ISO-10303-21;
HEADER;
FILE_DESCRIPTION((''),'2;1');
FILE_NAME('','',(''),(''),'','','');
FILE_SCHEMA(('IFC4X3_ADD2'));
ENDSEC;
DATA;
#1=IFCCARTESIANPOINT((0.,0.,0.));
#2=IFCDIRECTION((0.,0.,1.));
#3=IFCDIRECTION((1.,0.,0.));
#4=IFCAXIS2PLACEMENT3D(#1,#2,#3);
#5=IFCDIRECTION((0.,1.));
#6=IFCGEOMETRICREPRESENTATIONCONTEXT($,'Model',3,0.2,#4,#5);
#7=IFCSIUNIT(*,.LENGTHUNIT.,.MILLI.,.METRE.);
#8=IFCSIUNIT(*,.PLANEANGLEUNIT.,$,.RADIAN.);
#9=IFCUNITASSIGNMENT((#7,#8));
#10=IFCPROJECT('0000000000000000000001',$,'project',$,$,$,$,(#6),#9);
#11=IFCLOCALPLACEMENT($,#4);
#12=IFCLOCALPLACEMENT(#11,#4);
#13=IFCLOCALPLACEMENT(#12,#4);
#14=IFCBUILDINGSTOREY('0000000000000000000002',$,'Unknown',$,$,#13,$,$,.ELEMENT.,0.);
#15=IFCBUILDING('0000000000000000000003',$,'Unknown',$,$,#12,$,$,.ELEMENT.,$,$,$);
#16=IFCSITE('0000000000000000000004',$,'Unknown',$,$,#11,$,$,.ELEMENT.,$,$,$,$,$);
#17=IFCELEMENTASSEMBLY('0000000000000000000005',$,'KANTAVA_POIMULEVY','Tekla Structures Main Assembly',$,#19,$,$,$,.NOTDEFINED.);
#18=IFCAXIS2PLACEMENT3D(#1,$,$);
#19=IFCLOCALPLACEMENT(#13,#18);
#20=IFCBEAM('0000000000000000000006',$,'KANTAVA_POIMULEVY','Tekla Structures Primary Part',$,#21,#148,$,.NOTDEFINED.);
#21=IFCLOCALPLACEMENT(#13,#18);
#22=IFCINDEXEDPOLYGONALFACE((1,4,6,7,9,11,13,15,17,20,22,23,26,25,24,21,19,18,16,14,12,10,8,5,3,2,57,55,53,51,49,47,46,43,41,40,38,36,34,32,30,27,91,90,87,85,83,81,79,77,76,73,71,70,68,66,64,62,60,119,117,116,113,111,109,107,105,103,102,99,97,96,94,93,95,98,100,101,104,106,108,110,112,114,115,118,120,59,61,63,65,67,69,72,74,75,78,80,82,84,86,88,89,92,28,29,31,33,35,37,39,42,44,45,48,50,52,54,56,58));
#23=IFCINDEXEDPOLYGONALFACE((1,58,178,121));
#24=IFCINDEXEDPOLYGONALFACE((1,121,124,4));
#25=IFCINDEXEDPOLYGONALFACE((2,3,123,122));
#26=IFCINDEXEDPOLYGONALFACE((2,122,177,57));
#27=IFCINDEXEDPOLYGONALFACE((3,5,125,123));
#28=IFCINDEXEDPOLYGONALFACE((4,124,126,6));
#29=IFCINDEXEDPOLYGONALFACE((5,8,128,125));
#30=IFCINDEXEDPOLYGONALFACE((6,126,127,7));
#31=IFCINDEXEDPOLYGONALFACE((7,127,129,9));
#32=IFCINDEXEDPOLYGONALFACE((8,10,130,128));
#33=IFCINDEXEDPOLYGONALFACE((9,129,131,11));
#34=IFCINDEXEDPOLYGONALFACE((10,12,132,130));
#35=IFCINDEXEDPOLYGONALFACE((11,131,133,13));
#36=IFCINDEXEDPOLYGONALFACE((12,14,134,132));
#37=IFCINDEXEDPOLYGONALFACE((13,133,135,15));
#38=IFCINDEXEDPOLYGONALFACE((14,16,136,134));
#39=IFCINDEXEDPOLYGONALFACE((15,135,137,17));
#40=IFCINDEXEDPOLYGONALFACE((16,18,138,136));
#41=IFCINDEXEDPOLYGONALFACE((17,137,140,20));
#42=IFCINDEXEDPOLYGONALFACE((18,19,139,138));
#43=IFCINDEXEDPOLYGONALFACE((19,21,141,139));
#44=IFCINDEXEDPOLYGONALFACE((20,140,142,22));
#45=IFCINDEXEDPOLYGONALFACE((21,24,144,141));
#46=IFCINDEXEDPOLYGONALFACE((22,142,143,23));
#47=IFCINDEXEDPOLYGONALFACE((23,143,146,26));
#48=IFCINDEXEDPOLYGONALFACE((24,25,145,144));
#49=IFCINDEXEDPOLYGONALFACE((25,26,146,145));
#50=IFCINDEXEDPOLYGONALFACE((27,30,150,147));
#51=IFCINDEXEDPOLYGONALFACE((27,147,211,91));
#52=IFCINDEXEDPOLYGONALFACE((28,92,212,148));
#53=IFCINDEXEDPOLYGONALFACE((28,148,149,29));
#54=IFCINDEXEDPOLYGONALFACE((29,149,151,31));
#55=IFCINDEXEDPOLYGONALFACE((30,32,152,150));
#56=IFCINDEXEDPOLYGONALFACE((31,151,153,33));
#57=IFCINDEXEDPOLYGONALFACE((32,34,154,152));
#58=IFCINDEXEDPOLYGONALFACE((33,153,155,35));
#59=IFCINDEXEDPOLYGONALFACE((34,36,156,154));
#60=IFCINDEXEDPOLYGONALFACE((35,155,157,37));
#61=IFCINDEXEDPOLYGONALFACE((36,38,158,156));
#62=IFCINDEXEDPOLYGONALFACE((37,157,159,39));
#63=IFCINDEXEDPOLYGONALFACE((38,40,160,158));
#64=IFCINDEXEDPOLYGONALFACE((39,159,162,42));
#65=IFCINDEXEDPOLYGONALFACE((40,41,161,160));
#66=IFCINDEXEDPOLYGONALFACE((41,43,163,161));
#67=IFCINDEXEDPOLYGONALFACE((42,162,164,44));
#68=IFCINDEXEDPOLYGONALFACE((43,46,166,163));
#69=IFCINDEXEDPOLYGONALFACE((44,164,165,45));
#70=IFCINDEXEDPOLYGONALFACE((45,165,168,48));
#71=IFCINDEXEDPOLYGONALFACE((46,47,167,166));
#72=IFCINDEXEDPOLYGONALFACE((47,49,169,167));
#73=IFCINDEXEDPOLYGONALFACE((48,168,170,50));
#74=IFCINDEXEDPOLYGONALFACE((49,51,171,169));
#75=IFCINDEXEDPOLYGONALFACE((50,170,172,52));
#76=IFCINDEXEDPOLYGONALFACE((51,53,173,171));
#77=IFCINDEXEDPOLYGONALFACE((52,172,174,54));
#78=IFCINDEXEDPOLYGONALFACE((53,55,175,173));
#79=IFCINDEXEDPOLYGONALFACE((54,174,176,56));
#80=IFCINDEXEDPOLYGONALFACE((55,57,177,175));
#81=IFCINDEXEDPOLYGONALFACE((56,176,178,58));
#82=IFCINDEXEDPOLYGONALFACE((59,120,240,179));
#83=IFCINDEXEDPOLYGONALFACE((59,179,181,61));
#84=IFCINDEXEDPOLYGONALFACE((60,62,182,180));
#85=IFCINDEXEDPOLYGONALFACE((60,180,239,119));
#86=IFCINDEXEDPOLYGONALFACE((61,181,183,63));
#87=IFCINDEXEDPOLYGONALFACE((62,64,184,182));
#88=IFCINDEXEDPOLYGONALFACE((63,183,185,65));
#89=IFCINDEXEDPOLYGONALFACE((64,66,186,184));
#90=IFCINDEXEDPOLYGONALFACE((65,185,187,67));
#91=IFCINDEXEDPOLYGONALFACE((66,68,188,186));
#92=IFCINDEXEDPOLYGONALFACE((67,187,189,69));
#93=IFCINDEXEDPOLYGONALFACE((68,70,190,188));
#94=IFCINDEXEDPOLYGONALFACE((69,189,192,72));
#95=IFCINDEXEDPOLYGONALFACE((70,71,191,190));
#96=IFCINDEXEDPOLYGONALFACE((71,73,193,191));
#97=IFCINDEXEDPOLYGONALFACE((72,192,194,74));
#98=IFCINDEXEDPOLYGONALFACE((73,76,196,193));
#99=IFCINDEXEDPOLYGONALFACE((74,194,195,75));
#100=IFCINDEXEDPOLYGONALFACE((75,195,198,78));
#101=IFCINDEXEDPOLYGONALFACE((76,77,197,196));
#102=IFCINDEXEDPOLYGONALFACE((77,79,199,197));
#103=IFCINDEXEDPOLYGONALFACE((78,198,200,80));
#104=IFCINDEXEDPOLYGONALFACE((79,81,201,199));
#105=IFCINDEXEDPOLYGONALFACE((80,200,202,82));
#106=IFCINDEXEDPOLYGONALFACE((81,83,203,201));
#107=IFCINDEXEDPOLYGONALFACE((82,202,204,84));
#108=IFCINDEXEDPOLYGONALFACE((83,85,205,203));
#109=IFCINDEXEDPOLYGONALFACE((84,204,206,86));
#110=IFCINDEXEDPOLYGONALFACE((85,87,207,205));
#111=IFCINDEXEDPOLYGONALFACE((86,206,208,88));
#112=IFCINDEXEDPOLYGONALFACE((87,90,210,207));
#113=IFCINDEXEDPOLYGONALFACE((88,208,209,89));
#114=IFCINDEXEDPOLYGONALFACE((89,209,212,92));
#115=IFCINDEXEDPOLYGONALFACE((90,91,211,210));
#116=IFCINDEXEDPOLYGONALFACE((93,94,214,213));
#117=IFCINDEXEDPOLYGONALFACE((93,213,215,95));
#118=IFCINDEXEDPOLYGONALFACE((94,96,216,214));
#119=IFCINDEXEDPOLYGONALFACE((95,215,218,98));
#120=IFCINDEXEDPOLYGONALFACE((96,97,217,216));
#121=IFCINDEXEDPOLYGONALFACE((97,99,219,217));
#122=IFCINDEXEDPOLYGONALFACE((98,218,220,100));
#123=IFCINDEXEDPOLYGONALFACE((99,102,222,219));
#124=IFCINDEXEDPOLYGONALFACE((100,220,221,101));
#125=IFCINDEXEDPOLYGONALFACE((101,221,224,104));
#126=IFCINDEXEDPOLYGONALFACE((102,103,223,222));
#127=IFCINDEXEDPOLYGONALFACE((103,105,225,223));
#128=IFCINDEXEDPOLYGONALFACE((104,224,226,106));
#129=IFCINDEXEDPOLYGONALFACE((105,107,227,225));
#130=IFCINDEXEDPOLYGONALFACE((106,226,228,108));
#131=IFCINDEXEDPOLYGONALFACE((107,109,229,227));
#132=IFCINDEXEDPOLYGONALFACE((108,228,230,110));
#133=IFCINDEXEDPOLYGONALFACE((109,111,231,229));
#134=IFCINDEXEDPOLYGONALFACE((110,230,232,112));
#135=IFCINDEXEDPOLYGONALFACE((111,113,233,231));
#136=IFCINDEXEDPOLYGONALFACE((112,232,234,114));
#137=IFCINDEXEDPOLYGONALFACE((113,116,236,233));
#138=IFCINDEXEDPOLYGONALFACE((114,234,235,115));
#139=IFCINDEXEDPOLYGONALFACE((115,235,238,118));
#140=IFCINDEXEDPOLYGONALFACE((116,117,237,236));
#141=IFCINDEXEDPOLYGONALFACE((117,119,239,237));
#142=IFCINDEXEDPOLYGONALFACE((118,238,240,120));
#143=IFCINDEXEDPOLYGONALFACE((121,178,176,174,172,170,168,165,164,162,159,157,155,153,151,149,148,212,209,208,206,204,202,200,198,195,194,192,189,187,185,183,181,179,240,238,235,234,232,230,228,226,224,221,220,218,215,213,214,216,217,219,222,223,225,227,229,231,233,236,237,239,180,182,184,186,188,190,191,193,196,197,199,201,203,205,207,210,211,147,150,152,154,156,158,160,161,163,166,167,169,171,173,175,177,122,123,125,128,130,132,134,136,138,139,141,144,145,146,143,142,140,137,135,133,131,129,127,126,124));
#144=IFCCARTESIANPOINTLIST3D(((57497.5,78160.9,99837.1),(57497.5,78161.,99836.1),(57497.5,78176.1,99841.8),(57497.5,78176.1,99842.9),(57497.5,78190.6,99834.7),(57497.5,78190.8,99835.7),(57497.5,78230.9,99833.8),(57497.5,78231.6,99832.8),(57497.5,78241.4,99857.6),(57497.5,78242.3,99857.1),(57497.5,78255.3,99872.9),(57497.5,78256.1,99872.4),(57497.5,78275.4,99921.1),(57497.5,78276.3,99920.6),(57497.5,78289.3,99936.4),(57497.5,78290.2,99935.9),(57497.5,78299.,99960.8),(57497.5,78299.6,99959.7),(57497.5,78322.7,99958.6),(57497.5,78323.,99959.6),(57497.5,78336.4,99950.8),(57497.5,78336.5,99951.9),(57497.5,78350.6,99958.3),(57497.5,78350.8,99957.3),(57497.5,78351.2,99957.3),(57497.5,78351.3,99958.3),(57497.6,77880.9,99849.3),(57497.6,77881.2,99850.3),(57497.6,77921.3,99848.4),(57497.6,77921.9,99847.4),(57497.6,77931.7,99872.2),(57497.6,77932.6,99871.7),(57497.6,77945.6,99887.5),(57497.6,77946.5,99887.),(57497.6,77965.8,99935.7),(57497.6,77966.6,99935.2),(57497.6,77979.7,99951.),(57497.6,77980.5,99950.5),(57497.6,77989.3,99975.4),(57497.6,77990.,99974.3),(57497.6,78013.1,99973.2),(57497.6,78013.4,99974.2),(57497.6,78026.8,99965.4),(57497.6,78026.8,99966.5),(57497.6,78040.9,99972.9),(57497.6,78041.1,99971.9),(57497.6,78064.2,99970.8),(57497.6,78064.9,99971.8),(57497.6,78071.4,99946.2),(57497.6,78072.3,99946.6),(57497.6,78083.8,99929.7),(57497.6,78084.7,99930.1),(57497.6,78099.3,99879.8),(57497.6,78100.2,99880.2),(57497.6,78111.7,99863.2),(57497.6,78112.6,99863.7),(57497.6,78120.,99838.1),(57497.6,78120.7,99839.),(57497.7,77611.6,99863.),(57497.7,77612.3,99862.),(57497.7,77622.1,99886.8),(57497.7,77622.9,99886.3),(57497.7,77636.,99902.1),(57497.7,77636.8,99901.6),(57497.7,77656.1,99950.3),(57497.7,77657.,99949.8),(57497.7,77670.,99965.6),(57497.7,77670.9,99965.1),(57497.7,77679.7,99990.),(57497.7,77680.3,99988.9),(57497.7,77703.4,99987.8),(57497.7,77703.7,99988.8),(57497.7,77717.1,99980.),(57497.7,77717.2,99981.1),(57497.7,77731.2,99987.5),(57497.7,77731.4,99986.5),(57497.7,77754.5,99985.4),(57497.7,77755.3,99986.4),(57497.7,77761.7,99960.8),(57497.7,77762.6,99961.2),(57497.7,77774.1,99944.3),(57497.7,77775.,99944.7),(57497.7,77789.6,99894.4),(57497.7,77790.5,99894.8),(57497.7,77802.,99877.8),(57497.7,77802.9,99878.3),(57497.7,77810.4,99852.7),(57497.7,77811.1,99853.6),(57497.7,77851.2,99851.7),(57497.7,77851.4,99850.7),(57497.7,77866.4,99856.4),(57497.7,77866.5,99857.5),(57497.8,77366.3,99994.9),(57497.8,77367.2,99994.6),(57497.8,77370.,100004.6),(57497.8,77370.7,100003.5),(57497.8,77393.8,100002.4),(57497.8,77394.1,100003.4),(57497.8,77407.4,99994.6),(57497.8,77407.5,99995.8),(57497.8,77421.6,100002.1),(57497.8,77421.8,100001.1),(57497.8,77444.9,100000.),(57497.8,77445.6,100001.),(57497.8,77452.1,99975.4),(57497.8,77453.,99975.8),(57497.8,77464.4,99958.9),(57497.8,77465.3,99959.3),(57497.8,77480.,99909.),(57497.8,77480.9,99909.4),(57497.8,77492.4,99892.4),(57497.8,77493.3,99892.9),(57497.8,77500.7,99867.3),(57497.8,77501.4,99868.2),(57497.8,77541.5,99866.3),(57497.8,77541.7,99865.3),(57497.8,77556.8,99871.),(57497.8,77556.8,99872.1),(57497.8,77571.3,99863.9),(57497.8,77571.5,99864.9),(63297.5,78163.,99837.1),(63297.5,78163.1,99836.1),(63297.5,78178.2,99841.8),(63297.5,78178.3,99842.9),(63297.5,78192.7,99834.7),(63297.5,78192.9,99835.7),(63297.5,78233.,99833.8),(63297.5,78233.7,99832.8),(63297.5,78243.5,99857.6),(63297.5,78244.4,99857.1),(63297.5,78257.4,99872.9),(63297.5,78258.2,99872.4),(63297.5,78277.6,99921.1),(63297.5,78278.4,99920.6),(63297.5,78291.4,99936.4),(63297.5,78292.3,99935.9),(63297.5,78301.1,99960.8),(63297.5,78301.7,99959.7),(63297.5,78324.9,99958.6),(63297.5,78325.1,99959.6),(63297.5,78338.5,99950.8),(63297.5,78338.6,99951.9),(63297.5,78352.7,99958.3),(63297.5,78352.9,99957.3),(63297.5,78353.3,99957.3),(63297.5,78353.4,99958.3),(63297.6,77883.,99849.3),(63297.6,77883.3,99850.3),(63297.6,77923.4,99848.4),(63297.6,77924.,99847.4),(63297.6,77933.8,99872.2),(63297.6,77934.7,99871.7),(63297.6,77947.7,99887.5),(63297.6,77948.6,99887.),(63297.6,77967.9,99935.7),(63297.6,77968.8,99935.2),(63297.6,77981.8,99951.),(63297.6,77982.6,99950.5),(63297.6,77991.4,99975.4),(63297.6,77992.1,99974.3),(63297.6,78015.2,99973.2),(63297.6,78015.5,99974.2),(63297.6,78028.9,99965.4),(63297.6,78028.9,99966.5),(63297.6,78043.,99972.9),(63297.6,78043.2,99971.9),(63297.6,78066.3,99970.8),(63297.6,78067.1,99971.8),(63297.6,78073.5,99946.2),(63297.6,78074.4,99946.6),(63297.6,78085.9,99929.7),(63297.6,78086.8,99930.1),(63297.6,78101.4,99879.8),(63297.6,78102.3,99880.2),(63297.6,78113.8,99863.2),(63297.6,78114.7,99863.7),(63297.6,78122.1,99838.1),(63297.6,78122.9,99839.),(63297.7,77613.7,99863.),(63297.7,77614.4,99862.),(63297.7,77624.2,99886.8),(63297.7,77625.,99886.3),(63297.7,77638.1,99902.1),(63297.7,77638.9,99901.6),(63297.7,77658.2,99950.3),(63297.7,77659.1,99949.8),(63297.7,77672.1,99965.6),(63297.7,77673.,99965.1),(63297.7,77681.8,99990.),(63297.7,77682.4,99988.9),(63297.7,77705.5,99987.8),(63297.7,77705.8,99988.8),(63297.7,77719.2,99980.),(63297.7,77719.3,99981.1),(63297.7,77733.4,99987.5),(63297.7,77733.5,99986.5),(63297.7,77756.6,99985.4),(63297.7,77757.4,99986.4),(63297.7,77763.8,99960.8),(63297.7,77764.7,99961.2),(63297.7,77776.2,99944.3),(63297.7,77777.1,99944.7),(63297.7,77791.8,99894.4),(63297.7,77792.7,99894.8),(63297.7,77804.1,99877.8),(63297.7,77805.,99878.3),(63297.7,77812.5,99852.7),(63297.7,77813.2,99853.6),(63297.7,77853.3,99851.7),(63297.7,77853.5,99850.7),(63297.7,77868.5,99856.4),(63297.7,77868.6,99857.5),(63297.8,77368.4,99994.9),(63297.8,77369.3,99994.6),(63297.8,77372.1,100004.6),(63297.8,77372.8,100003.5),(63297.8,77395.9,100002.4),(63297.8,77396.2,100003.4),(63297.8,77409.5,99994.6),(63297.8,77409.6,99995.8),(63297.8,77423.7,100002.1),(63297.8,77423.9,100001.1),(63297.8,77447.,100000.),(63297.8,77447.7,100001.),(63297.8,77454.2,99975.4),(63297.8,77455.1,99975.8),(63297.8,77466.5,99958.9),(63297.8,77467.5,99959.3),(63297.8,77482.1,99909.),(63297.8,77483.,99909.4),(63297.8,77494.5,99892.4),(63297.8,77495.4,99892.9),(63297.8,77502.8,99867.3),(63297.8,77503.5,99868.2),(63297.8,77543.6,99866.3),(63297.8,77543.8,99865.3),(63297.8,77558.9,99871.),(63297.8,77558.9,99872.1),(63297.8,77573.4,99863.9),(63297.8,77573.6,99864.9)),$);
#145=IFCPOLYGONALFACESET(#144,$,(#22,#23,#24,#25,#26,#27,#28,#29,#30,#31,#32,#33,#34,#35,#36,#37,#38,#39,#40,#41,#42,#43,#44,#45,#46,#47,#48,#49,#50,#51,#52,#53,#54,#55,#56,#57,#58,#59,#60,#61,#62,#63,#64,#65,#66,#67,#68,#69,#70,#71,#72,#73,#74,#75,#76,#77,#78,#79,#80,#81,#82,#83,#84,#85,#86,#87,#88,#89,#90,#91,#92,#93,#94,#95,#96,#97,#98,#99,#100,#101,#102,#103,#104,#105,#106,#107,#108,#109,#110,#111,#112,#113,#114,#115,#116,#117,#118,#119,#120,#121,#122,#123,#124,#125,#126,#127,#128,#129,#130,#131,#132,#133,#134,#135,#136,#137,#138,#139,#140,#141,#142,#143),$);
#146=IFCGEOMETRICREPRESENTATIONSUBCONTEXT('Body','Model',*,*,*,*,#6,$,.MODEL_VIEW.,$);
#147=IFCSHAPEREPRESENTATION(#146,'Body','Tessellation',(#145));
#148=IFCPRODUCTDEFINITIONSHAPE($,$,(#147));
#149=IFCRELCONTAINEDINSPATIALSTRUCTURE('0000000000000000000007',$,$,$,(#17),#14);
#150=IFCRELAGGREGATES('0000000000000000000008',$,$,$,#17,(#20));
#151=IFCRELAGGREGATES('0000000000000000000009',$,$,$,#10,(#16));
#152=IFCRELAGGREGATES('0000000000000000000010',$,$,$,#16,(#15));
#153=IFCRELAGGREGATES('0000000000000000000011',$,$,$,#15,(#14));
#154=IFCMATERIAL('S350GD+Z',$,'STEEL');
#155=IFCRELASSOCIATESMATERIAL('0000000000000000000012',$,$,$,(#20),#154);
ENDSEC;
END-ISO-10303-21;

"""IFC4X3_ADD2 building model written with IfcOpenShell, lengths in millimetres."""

from ifc_helpers import new_model, si_unit, direction, frame, origin_with_axes, place, context, subcontext, project, spatial, line, indexed_curve, outline, extrude, material, element, aggregate, save


model = new_model("IFC4X3_ADD2")

# Units and contexts
model_context = context("Model", 3, precision=0.2, world=origin_with_axes(), true_north=direction((0.0, 1.0)))
body_context = subcontext(model_context, "Body", "Model", "MODEL_VIEW")
ifc_project = project(units=[si_unit("LENGTHUNIT", "METRE", prefix="MILLI"), si_unit("PLANEANGLEUNIT", "RADIAN")], contexts=[model_context])

# Site, building, storey
site_placement = place(None, origin_with_axes())
site = spatial("IfcSite", under=ifc_project, at=site_placement, Name="Unknown", CompositionType="ELEMENT")
building_placement = place(site_placement, origin_with_axes())
building = spatial("IfcBuilding", under=site, at=building_placement, Name="Unknown", CompositionType="ELEMENT")
storey_placement = place(building_placement, origin_with_axes())
storey = spatial("IfcBuildingStorey", under=building, at=storey_placement, Name="Unknown", CompositionType="ELEMENT", Elevation=0.0)

# Element assembly, beam
ifc_material_1 = material(Name="S350GD+Z", Category="STEEL")
assembly_1_placement = place(storey_placement, frame((63297.7, 77871.3, 99915.5), z_axis=(-0.000363, 0.99889, -0.047106), x_axis=(-1.0, -0.000363, 0.0)))
assembly_1 = element("IfcElementAssembly", 1, at=assembly_1_placement, inside=storey, Name="KANTAVA_POIMULEVY", Description="Tekla Structures Main Assembly", PredefinedType="NOTDEFINED")
beam_1_placement = place(assembly_1_placement, origin_with_axes())
beam_1 = element("IfcBeam", 2, at=beam_1_placement, material=ifc_material_1, Name="KANTAVA_POIMULEVY", Description="Tekla Structures Primary Part", PredefinedType="NOTDEFINED", context=body_context, shape_type="SolidModel", body=[
    extrude(outline(indexed_curve([(479.5, 65.5), (478.8, 65.5), (465.0, 58.5), (451.2, 65.5), (427.1, 65.5), (418.6, 40.7), (405.5, 24.8), (387.6, -24.3), (374.5, -40.2), (365.1, -64.5), (325.0, -64.5), (310.0, -58.1), (295.0, -64.5), (254.8, -64.5), (245.5, -40.2), (232.4, -24.3), (214.5, 24.8), (201.4, 40.7), (192.9, 65.5), (168.8, 65.5), (155.0, 58.5), (141.2, 65.5), (117.1, 65.5), (108.6, 40.7), (95.5, 24.8), (77.6, -24.3), (64.5, -40.2), (55.1, -64.5), (15.0, -64.5), (0.0, -58.1), (-15.0, -64.5), (-55.2, -64.5), (-64.5, -40.2), (-77.6, -24.3), (-95.5, 24.8), (-108.6, 40.7), (-117.2, 65.5), (-141.2, 65.5), (-155.0, 58.5), (-168.8, 65.5), (-192.9, 65.5), (-201.4, 40.7), (-214.5, 24.8), (-232.4, -24.3), (-245.5, -40.2), (-254.9, -64.5), (-295.0, -64.5), (-310.0, -58.1), (-325.0, -64.5), (-365.2, -64.5), (-374.5, -40.2), (-387.6, -24.3), (-405.5, 24.8), (-418.6, 40.7), (-427.1, 65.5), (-451.2, 65.5), (-465.0, 58.5), (-478.8, 65.5), (-502.9, 65.5), (-506.2, 55.7), (-505.2, 55.4), (-502.1, 64.5), (-479.0, 64.5), (-465.0, 57.3), (-451.0, 64.5), (-427.9, 64.5), (-419.5, 40.2), (-406.4, 24.3), (-388.5, -24.8), (-375.4, -40.7), (-365.9, -65.5), (-324.8, -65.5), (-310.0, -59.1), (-295.2, -65.5), (-254.2, -65.5), (-244.6, -40.7), (-231.5, -24.8), (-213.6, 24.3), (-200.5, 40.2), (-192.1, 64.5), (-169.0, 64.5), (-155.0, 57.3), (-141.0, 64.5), (-117.9, 64.5), (-109.5, 40.2), (-96.4, 24.3), (-78.5, -24.8), (-65.4, -40.7), (-55.9, -65.5), (-14.8, -65.5), (0.0, -59.1), (14.8, -65.5), (55.8, -65.5), (65.4, -40.7), (78.5, -24.8), (96.4, 24.3), (109.5, 40.2), (117.8, 64.5), (141.0, 64.5), (155.0, 57.3), (169.0, 64.5), (192.1, 64.5), (200.5, 40.2), (213.6, 24.3), (231.5, -24.8), (244.6, -40.7), (254.1, -65.5), (295.2, -65.5), (310.0, -59.1), (324.8, -65.5), (365.8, -65.5), (375.4, -40.7), (388.5, -24.8), (406.4, 24.3), (419.5, 40.2), (427.9, 64.5), (451.0, 64.5), (465.0, 57.3), (479.0, 64.5), (479.5, 64.5)], segments=[line(1, 2, 3, 4, 5, 6, 7, 8, 9, 10, 11, 12, 13, 14, 15, 16, 17, 18, 19, 20, 21, 22, 23, 24, 25, 26, 27, 28, 29, 30, 31, 32, 33, 34, 35, 36, 37, 38, 39, 40, 41, 42, 43, 44, 45, 46, 47, 48, 49, 50, 51, 52, 53, 54, 55, 56, 57, 58, 59, 60, 61, 62, 63, 64, 65, 66, 67, 68, 69, 70, 71, 72, 73, 74, 75, 76, 77, 78, 79, 80, 81, 82, 83, 84, 85, 86, 87, 88, 89, 90, 91, 92, 93, 94, 95, 96, 97, 98, 99, 100, 101, 102, 103, 104, 105, 106, 107, 108, 109, 110, 111, 112, 113, 114, 115, 116, 117, 118, 119, 120, 1)])), frame((0.0, 0.0, 0.0), z_axis=(-1.0, 0.0, 0.0), x_axis=(0.0, 0.0, 1.0)), (0.0, 0.0, -1.0), 5800.0),
])
aggregate(assembly_1, [beam_1])

save(model, "model.ifc")
